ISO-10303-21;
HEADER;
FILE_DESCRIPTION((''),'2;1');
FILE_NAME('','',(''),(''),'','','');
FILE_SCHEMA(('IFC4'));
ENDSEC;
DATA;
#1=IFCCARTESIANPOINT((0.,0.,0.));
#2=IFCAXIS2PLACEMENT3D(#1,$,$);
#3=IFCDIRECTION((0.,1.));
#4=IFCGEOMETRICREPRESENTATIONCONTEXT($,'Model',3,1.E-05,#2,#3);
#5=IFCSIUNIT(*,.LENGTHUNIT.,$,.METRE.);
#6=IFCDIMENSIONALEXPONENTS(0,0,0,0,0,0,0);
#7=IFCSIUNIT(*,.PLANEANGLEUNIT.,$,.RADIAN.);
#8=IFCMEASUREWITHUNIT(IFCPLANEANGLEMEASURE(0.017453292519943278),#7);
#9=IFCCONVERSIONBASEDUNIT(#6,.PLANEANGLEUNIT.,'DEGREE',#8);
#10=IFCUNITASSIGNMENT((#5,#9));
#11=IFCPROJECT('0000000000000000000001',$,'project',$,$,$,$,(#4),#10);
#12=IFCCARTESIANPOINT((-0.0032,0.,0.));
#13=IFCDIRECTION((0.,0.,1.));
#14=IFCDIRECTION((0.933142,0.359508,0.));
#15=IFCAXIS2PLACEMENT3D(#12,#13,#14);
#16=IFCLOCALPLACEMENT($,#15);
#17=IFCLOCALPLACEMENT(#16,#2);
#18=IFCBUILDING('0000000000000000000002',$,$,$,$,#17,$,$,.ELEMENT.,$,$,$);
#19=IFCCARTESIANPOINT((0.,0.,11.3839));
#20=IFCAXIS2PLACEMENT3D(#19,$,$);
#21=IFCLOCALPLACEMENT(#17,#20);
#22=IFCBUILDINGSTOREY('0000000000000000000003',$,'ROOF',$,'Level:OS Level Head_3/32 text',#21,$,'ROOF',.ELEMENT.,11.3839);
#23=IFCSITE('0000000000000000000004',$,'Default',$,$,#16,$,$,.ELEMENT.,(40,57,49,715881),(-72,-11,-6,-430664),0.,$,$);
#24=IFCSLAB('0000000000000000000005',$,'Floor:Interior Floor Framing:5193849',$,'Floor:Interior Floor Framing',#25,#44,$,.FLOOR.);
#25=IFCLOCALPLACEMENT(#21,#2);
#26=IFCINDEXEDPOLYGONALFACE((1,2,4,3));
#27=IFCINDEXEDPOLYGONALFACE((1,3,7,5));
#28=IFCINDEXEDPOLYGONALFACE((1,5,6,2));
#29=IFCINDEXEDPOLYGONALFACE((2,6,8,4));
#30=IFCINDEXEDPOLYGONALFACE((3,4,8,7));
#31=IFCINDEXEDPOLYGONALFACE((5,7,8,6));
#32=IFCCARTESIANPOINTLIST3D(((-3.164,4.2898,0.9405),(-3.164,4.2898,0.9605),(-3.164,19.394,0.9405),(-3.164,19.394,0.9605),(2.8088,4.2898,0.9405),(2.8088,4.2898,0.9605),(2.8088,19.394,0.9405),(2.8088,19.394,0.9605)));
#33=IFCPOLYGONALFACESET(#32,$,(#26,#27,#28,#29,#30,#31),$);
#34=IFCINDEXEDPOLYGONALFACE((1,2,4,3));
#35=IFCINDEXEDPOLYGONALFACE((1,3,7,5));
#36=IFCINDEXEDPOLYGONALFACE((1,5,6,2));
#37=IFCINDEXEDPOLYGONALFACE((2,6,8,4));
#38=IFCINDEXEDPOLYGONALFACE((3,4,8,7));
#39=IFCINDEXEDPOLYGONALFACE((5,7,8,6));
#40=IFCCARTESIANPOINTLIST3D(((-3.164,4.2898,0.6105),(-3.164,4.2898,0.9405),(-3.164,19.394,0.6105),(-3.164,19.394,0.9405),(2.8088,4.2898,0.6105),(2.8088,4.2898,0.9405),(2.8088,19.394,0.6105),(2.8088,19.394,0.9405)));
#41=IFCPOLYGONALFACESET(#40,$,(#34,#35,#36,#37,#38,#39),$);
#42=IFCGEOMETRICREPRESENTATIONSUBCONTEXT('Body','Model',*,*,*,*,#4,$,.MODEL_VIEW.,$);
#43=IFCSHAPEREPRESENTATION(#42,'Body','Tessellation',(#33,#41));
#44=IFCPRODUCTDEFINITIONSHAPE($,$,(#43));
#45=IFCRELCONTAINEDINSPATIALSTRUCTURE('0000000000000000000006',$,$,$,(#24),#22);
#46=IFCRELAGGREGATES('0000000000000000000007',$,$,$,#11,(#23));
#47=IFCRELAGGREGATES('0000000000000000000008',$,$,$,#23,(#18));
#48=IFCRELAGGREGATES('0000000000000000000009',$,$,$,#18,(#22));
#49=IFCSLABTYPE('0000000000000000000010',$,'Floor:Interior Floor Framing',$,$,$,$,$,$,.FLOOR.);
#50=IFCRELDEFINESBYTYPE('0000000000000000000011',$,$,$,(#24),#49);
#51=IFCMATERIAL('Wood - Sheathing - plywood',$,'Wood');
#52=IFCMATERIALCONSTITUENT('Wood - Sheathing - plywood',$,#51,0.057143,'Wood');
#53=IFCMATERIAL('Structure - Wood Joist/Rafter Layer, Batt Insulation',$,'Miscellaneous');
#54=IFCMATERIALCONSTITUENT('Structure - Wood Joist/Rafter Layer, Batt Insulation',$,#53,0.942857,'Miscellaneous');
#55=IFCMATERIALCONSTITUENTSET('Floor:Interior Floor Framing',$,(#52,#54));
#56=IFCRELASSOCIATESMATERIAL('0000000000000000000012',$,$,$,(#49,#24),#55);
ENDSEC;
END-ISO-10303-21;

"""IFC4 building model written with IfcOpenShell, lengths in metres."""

from ifc_helpers import new_model, entity, si_unit, converted_unit, direction, frame, origin, place, context, subcontext, project, spatial, indexed_curve, outline, extrude, material, constituent, constituent_set, type_object, element, save


model = new_model("IFC4")

# Units and contexts
model_context = context("Model", 3, precision=1e-05, world=origin(), true_north=direction((0.0, 1.0)))
body_context = subcontext(model_context, "Body", "Model", "MODEL_VIEW")
ifc_project = project(units=[si_unit("LENGTHUNIT", "METRE"), converted_unit("PLANEANGLEUNIT", "DEGREE", entity("IfcPlaneAngleMeasure", 0.017453292519943278), si_unit("PLANEANGLEUNIT", "RADIAN"), dimensions=[0, 0, 0, 0, 0, 0, 0])], contexts=[model_context])

# Site, building, storey
site_placement = place(None, frame((-0.0032, 0.0, 0.0), z_axis=(0.0, 0.0, 1.0), x_axis=(0.933142, 0.359508, 0.0)))
site = spatial("IfcSite", under=ifc_project, at=site_placement, Name="Default", CompositionType="ELEMENT", RefLatitude=(40, 57, 49, 715881), RefLongitude=(-72, -11, -6, -430664), RefElevation=0.0)
building_placement = place(site_placement, origin())
building = spatial("IfcBuilding", under=site, at=building_placement, CompositionType="ELEMENT")
storey_placement = place(building_placement, frame((0.0, 0.0, 11.3839)))
storey = spatial("IfcBuildingStorey", under=building, at=storey_placement, Name="ROOF", ObjectType="Level:OS Level Head_3/32 text", LongName="ROOF", CompositionType="ELEMENT", Elevation=11.3839)

# Slab
ifc_material_1 = material(Name="Wood - Sheathing - plywood", Category="Wood")
ifc_constituent_1 = constituent(ifc_material_1, Name="Wood - Sheathing - plywood", Category="Wood", fraction=0.057143)
ifc_material_2 = material(Name="Structure - Wood Joist/Rafter Layer, Batt Insulation", Category="Miscellaneous")
ifc_constituent_2 = constituent(ifc_material_2, Name="Structure - Wood Joist/Rafter Layer, Batt Insulation", Category="Miscellaneous", fraction=0.942857)
ifc_constituent_set = constituent_set(constituents=[ifc_constituent_1, ifc_constituent_2], Name="Floor:Interior Floor Framing")
slab_type = type_object("IfcSlabType", Name="Floor:Interior Floor Framing", PredefinedType="FLOOR", material=ifc_constituent_set)
slab_placement = place(storey_placement, origin())
element("IfcSlab", 1, at=slab_placement, inside=storey, type_object=slab_type, material=ifc_constituent_set, Name="Floor:Interior Floor Framing:5193849", ObjectType="Floor:Interior Floor Framing", PredefinedType="FLOOR", context=body_context, shape_type="SweptSolid", body=[
    extrude(outline(indexed_curve([(-2.9864, -7.5521), (2.9864, -7.5521), (2.9864, 7.5521), (-2.9864, 7.5521), (-2.9864, -7.5521)], self_intersect=False)), frame((-0.1776, 11.8419, 0.9405), z_axis=(0.0, 0.0, 1.0), x_axis=(-1.0, 0.0, 0.0)), (0.0, 0.0, 1.0), 0.02),
    extrude(outline(indexed_curve([(-2.9864, -7.5521), (2.9864, -7.5521), (2.9864, 7.5521), (-2.9864, 7.5521), (-2.9864, -7.5521)], self_intersect=False)), frame((-0.1776, 11.8419, 0.6105), z_axis=(0.0, 0.0, 1.0), x_axis=(-1.0, 0.0, 0.0)), (0.0, 0.0, 1.0), 0.33),
])

save(model, "model.ifc")
